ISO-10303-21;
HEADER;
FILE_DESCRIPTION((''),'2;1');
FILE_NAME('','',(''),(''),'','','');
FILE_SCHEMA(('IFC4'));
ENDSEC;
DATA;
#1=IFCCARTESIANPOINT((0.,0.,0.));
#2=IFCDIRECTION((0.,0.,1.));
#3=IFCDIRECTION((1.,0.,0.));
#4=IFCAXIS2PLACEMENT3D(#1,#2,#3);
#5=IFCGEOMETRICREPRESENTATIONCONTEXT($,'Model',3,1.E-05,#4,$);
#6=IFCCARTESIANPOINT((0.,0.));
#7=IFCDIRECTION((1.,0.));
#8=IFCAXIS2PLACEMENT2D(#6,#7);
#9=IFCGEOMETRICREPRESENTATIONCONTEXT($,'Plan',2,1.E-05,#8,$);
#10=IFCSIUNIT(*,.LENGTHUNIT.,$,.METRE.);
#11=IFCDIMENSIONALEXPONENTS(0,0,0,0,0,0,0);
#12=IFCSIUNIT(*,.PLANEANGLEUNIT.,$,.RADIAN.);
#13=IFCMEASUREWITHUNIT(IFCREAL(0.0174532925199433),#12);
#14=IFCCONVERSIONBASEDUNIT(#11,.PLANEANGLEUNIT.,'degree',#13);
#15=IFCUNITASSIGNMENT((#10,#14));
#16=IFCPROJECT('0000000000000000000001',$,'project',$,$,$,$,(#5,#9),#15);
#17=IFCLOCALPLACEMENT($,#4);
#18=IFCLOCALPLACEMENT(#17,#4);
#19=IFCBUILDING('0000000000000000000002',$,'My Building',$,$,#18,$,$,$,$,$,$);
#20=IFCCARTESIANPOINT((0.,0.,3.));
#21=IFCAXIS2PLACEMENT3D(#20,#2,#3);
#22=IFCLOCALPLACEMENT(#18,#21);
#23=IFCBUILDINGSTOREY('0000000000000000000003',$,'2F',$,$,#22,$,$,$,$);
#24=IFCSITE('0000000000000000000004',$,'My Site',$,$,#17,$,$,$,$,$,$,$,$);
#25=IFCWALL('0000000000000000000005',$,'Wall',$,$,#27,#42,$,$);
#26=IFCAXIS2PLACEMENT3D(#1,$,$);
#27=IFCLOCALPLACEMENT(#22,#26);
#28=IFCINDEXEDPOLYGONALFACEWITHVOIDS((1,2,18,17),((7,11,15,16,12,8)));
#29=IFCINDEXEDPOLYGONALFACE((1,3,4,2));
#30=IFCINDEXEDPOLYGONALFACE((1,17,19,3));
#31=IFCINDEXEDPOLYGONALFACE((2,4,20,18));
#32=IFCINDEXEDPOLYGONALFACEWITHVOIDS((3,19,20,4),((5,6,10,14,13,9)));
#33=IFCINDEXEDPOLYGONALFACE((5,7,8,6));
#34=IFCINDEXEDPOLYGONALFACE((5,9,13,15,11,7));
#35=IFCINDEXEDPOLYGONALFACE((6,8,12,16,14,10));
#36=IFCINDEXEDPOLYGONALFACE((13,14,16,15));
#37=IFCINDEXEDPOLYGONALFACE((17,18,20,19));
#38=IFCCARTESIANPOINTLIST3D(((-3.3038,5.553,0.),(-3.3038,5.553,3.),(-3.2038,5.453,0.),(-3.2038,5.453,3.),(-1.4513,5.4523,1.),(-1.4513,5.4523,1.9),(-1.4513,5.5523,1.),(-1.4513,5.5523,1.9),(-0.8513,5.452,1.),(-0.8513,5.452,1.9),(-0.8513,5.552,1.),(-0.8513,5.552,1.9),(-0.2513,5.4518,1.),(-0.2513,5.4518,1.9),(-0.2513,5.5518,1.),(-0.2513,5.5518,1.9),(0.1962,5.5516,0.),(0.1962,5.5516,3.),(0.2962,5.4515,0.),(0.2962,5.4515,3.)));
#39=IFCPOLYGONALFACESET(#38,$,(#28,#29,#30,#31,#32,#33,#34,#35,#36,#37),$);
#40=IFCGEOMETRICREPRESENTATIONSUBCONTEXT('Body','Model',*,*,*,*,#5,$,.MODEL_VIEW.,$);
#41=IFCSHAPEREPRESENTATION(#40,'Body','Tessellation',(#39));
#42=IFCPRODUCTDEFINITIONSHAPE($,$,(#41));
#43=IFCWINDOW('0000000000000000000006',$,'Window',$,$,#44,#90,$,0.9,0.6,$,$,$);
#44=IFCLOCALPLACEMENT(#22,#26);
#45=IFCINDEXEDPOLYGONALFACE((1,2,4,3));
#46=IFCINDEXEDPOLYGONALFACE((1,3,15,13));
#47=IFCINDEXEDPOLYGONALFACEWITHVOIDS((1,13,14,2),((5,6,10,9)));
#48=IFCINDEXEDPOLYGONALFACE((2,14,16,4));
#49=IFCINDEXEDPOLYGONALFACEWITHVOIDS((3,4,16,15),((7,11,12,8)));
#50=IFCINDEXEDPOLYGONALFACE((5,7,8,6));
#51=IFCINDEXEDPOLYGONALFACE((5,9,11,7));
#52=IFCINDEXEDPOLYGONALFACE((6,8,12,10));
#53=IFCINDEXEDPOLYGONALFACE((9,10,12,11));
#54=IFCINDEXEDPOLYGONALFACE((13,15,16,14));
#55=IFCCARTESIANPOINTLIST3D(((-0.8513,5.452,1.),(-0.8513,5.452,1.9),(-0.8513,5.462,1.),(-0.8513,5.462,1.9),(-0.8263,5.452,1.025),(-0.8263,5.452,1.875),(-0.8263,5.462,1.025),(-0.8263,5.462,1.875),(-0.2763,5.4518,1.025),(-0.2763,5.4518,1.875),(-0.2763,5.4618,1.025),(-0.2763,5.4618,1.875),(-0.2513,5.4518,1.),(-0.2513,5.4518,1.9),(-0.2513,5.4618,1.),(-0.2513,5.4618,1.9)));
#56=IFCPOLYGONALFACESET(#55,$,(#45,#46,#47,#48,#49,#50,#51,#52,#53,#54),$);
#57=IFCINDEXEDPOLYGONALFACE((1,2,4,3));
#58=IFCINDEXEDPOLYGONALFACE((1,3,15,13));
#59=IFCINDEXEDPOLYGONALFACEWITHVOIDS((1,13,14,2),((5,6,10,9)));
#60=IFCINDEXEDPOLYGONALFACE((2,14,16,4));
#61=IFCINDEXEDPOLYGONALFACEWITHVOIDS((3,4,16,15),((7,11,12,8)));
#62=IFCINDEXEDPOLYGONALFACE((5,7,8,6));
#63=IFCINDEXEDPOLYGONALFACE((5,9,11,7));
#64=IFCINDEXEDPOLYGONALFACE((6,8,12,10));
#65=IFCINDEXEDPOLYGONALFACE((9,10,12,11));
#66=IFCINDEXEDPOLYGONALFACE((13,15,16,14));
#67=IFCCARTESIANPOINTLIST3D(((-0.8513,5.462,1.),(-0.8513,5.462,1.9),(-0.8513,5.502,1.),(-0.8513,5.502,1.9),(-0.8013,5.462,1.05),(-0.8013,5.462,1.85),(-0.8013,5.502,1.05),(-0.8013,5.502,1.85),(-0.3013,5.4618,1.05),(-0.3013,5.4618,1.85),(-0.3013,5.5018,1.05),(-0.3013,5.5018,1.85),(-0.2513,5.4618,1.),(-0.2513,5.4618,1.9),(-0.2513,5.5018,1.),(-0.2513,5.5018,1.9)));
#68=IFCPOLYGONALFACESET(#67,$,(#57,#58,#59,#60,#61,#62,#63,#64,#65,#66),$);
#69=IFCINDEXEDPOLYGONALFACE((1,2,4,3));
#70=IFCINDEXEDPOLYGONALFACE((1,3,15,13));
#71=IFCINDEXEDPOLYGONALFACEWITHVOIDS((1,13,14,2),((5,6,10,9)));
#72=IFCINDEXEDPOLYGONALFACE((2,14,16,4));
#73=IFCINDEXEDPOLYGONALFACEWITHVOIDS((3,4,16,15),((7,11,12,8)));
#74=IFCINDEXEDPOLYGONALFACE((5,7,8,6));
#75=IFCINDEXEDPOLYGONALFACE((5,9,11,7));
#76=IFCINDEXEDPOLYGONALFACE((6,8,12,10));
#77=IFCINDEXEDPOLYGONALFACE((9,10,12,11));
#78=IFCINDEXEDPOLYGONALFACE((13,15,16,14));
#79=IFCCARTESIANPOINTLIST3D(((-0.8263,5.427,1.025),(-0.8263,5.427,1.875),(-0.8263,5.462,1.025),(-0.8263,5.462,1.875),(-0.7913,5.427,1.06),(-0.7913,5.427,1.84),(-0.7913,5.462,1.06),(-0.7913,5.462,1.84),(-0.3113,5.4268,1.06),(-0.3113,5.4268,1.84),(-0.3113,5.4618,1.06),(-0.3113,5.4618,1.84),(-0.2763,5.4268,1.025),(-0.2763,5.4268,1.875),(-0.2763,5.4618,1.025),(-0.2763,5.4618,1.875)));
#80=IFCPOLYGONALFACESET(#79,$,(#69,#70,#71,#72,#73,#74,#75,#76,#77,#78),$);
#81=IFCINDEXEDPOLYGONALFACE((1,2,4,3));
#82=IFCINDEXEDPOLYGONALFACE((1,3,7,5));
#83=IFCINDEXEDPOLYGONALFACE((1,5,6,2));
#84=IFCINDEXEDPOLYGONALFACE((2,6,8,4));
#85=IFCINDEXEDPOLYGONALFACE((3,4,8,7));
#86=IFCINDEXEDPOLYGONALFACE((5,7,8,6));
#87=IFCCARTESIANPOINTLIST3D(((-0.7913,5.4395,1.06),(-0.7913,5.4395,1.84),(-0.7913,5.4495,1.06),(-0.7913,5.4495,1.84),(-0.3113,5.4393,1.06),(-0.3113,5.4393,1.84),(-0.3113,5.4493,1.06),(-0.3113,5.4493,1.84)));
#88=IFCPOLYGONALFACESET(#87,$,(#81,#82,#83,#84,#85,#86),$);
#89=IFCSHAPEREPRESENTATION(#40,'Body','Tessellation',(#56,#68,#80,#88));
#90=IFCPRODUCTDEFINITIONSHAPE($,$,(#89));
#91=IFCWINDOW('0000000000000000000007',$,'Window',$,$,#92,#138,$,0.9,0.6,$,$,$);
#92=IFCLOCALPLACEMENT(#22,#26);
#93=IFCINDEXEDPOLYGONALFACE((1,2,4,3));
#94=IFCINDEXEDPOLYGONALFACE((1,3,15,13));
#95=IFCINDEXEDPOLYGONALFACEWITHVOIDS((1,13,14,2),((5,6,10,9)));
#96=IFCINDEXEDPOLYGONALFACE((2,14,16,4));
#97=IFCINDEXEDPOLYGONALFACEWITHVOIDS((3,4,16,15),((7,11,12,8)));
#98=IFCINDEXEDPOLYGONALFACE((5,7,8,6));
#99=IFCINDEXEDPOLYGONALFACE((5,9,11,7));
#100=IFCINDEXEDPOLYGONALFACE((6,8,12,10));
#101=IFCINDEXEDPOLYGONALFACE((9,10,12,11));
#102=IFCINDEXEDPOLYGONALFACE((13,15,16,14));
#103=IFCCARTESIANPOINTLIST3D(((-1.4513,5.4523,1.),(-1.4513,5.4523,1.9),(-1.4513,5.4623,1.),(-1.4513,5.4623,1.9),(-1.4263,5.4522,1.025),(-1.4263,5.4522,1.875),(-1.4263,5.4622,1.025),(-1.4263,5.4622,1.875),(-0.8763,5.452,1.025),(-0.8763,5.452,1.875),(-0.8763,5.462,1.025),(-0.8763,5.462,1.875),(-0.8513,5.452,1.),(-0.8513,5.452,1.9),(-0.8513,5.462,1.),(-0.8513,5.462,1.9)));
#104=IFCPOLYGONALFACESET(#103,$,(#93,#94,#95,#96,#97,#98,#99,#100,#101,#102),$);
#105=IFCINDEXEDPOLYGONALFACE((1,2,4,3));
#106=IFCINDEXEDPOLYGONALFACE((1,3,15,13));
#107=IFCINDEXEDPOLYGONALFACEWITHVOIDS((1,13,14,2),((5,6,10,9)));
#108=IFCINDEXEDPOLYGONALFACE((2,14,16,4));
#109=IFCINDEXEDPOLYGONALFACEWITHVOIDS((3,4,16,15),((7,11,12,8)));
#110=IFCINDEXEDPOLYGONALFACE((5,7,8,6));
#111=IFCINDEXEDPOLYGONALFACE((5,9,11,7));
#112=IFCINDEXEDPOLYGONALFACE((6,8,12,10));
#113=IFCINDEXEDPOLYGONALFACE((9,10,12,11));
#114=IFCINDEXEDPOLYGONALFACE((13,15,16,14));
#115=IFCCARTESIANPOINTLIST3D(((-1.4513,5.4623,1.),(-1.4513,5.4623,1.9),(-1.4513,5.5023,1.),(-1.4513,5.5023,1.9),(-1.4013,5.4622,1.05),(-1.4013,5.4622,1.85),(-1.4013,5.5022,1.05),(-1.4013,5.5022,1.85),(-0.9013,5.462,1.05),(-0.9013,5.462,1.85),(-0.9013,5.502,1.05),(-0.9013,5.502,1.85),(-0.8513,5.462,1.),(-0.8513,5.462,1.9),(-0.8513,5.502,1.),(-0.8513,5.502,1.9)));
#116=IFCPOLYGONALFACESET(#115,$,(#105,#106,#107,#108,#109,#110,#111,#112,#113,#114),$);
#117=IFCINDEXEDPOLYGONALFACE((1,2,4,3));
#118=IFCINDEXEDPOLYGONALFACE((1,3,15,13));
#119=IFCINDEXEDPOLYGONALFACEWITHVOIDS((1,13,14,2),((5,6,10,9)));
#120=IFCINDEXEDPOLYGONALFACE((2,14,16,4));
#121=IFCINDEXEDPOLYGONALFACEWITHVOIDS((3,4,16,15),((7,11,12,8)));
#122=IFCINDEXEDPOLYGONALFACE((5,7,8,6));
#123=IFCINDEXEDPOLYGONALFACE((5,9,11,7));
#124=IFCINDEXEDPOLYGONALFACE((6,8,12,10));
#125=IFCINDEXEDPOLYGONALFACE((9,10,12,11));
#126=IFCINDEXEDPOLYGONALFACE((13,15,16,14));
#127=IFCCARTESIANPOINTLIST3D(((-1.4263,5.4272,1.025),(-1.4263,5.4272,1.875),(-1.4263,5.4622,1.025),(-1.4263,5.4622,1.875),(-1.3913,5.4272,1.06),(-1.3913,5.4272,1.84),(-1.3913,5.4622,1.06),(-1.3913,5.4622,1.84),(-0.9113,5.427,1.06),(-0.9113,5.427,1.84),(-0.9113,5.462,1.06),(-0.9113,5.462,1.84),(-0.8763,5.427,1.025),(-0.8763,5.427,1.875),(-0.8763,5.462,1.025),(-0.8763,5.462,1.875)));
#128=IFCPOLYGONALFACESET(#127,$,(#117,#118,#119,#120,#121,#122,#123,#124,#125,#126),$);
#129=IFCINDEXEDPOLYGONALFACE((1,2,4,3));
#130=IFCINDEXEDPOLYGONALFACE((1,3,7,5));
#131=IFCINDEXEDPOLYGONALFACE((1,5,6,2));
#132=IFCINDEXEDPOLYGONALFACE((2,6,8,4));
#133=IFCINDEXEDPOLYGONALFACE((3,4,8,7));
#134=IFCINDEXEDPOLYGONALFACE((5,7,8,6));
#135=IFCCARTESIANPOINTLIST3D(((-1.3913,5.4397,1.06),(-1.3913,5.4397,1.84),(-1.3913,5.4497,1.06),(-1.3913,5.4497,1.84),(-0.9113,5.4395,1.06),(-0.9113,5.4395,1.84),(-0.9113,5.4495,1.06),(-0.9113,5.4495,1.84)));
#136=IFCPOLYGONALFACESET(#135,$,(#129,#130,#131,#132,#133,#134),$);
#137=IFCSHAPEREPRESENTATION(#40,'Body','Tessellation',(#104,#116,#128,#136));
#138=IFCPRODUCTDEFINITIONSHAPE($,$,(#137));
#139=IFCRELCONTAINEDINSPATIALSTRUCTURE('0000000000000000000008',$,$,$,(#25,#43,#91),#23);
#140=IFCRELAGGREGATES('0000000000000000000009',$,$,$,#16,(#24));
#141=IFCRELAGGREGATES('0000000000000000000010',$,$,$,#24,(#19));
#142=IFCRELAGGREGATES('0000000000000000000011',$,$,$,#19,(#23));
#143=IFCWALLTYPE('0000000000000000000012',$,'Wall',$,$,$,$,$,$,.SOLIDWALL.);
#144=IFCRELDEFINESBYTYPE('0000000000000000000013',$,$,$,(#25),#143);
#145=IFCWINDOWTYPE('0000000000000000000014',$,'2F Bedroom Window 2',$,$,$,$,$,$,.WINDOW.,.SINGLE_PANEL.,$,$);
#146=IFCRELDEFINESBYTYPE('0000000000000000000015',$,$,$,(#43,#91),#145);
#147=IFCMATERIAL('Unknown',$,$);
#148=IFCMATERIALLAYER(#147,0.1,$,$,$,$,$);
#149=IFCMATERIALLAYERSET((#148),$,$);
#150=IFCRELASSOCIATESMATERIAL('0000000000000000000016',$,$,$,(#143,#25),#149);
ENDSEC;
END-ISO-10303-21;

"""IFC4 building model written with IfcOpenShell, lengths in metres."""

from ifc_helpers import new_model, entity, si_unit, converted_unit, frame, origin_with_axes, origin_2d_with_axis, place, context, subcontext, project, spatial, line, indexed_curve, outline, extrude, shape, source, transform, mapped, material, layer, layer_set, layer_usage, type_object, type_shapes, element, fill, save


model = new_model("IFC4")

# Units and contexts
model_context = context("Model", 3, precision=1e-05, world=origin_with_axes())
plan_context = context("Plan", 2, precision=1e-05, world=origin_2d_with_axis())
body_context_1 = subcontext(model_context, "Body", "Model", "MODEL_VIEW")
body_context_2 = subcontext(plan_context, "Body", "Plan", "PLAN_VIEW")
ifc_project = project(units=[si_unit("LENGTHUNIT", "METRE"), converted_unit("PLANEANGLEUNIT", "degree", entity("IfcReal", 0.0174532925199433), si_unit("PLANEANGLEUNIT", "RADIAN"), dimensions=[0, 0, 0, 0, 0, 0, 0])], contexts=[model_context, plan_context])

# Site, building, storey
site_placement = place(None, origin_with_axes())
site = spatial("IfcSite", under=ifc_project, at=site_placement, Name="My Site")
building_placement = place(site_placement, origin_with_axes())
building = spatial("IfcBuilding", under=site, at=building_placement, Name="My Building")
storey_placement = place(building_placement, frame((0.0, 0.0, 3.0), z_axis=(0.0, 0.0, 1.0), x_axis=(1.0, 0.0, 0.0)))
storey = spatial("IfcBuildingStorey", under=building, at=storey_placement, Name="2F")

# Shared definitions
ifc_material = material(Name="Unknown")

# Shared definitions
ifc_layer_1 = layer(ifc_material, 0.1)
ifc_layer_set_1 = layer_set([ifc_layer_1])
wall_type = type_object("IfcWallType", Name="Wall", PredefinedType="SOLIDWALL", material=ifc_layer_set_1)

# Wall, openings, windows
ifc_layer_usage_1 = layer_usage(ifc_layer_set_1, "AXIS2", "POSITIVE", 0.0)
wall_1_placement = place(storey_placement, frame((0.1962, 5.5516, 0.0), z_axis=(0.0, 0.0, 1.0), x_axis=(-1.0, 0.000416, 0.0)))
wall_1 = element("IfcWall", 1, at=wall_1_placement, inside=storey, type_object=wall_type, material=ifc_layer_usage_1, Name="Wall", context=body_context_1, shape_type="SweptSolid", body=[
    extrude(outline(indexed_curve([(0.0, 0.0), (-0.1, 0.1), (3.4, 0.1), (3.5, 0.0)], segments=[line(1, 2, 3, 4, 1)])), origin_with_axes(), (0.0, 0.0, 1.0), 3.0),
])
shared_shape_1 = source(origin_with_axes(), body_context_1, "Body", "SweptSolid", [
    extrude(outline(indexed_curve([(0.0, 0.0), (0.6, 0.0), (0.6, 0.9), (0.0, 0.9)], segments=[line(1, 2, 3, 4, 1)])), frame((0.0, -0.6, 0.0), z_axis=(0.0, -1.0, 0.0), x_axis=(1.0, 0.0, 0.0)), (0.0, 0.0, -1.0), 1.2),
])
opening_1_placement = place(wall_1_placement, frame((0.4475, 0.0, 1.0), z_axis=(0.0, 0.0, 1.0), x_axis=(1.0, 0.0, 0.0)))
opening_1 = element("IfcOpeningElement", 2, at=opening_1_placement, cuts=wall_1, PredefinedType="OPENING", context=body_context_1, shape_type="MappedRepresentation", body=[
    mapped(shared_shape_1, transform((0.0, 0.0, 0.0), x_axis=(1.0, 0.0, 0.0), y_axis=(0.0, 1.0, 0.0), z_axis=(0.0, 0.0, 1.0), scale=1.0)),
])
opening_2_placement = place(wall_1_placement, frame((1.0475, 0.0, 1.0), z_axis=(0.0, 0.0, 1.0), x_axis=(1.0, 0.0, 0.0)))
opening_2 = element("IfcOpeningElement", 3, at=opening_2_placement, cuts=wall_1, PredefinedType="OPENING", context=body_context_1, shape_type="MappedRepresentation", body=[
    mapped(shared_shape_1, transform((0.0, 0.0, 0.0), x_axis=(1.0, 0.0, 0.0), y_axis=(0.0, 1.0, 0.0), z_axis=(0.0, 0.0, 1.0), scale=1.0)),
])
window_type_1 = type_object("IfcWindowType", Name="2F Bedroom Window 2", PartitioningType="SINGLE_PANEL", PredefinedType="WINDOW")
shared_shape_2 = source(origin_with_axes(), body_context_1, "Body", "SweptSolid", [
    extrude(outline(indexed_curve([(0.0, 0.0), (0.6, 0.0), (0.6, 0.9), (0.0, 0.9)], segments=[line(1, 2, 3, 4, 1)]), holes=[indexed_curve([(0.025, 0.025), (0.575, 0.025), (0.575, 0.875), (0.025, 0.875)], segments=[line(1, 2, 3, 4, 1)])]), frame((0.0, 0.09, 0.0), z_axis=(0.0, -1.0, 0.0), x_axis=(1.0, 0.0, 0.0)), (0.0, 0.0, -1.0), 0.01),
    extrude(outline(indexed_curve([(0.0, 0.0), (0.6, 0.0), (0.6, 0.9), (0.0, 0.9)], segments=[line(1, 2, 3, 4, 1)]), holes=[indexed_curve([(0.05, 0.05), (0.55, 0.05), (0.55, 0.85), (0.05, 0.85)], segments=[line(1, 2, 3, 4, 1)])]), frame((0.0, 0.05, 0.0), z_axis=(0.0, -1.0, 0.0), x_axis=(1.0, 0.0, 0.0)), (0.0, 0.0, -1.0), 0.04),
    extrude(outline(indexed_curve([(0.0, 0.0), (0.55, 0.0), (0.55, 0.85), (0.0, 0.85)], segments=[line(1, 2, 3, 4, 1)]), holes=[indexed_curve([(0.035, 0.035), (0.515, 0.035), (0.515, 0.815), (0.035, 0.815)], segments=[line(1, 2, 3, 4, 1)])]), frame((0.025, 0.09, 0.025), z_axis=(0.0, -1.0, 0.0), x_axis=(1.0, 0.0, 0.0)), (0.0, 0.0, -1.0), 0.035),
    extrude(outline(indexed_curve([(0.035, 0.035), (0.515, 0.035), (0.515, 0.815), (0.035, 0.815)], segments=[line(1, 2, 3, 4, 1)])), frame((0.025, 0.1025, 0.025), z_axis=(0.0, -1.0, 0.0), x_axis=(1.0, 0.0, 0.0)), (0.0, 0.0, -1.0), 0.01),
])
shared_shape_3 = source(origin_with_axes(), body_context_2, "Body", "Curve2D", [
    entity("IfcIndexedPolyCurve", entity("IfcCartesianPointList2D", [[0.05, 0.05], [0.55, 0.05]])),
    entity("IfcIndexedPolyCurve", entity("IfcCartesianPointList2D", [[0.0, 0.1], [0.025, 0.1], [0.025, 0.09], [0.05, 0.09], [0.05, 0.05], [0.0, 0.05]]), [entity("IfcLineIndex", [1, 2, 3, 4, 5, 6, 1])]),
    entity("IfcIndexedPolyCurve", entity("IfcCartesianPointList2D", [[0.6, 0.1], [0.575, 0.1], [0.575, 0.09], [0.55, 0.09], [0.55, 0.05], [0.6, 0.05]]), [entity("IfcLineIndex", [1, 2, 3, 4, 5, 6, 1])]),
    entity("IfcIndexedPolyCurve", entity("IfcCartesianPointList2D", [[0.025, 0.09], [0.06, 0.09], [0.06, 0.125], [0.025, 0.125]]), [entity("IfcLineIndex", [1, 2, 3, 4, 1])]),
    entity("IfcIndexedPolyCurve", entity("IfcCartesianPointList2D", [[0.575, 0.09], [0.54, 0.09], [0.54, 0.125], [0.575, 0.125]]), [entity("IfcLineIndex", [1, 2, 3, 4, 1])]),
    entity("IfcIndexedPolyCurve", entity("IfcCartesianPointList2D", [[0.06, 0.09], [0.54, 0.09]])),
    entity("IfcIndexedPolyCurve", entity("IfcCartesianPointList2D", [[0.06, 0.125], [0.54, 0.125]])),
    entity("IfcIndexedPolyCurve", entity("IfcCartesianPointList2D", [[0.06, 0.1075], [0.54, 0.1075]])),
])
type_shapes(window_type_1, [shared_shape_2, shared_shape_3])
window_1_placement = place(opening_1_placement, frame((0.0, 0.0, 0.0), z_axis=(0.0, 0.0, 1.0), x_axis=(1.0, 0.0, 0.0)))
window_1 = element("IfcWindow", 4, at=window_1_placement, inside=storey, type_object=window_type_1, Name="Window", OverallHeight=0.9, OverallWidth=0.6, shapes=[
    shape(body_context_1, "Body", "MappedRepresentation", [mapped(shared_shape_2, transform((0.0, 0.0, 0.0), x_axis=(1.0, 0.0, 0.0), y_axis=(0.0, 1.0, 0.0), z_axis=(0.0, 0.0, 1.0), scale=1.0))]),
    shape(body_context_2, "Body", "MappedRepresentation", [mapped(shared_shape_3, transform((0.0, 0.0, 0.0), x_axis=(1.0, 0.0, 0.0), y_axis=(0.0, 1.0, 0.0), z_axis=(0.0, 0.0, 1.0), scale=1.0))]),
])
fill(opening_1, window_1)
window_2_placement = place(opening_2_placement, origin_with_axes())
window_2 = element("IfcWindow", 5, at=window_2_placement, inside=storey, type_object=window_type_1, Name="Window", OverallHeight=0.9, OverallWidth=0.6, shapes=[
    shape(body_context_1, "Body", "MappedRepresentation", [mapped(shared_shape_2, transform((0.0, 0.0, 0.0), x_axis=(1.0, 0.0, 0.0), y_axis=(0.0, 1.0, 0.0), z_axis=(0.0, 0.0, 1.0), scale=1.0))]),
    shape(body_context_2, "Body", "MappedRepresentation", [mapped(shared_shape_3, transform((0.0, 0.0, 0.0), x_axis=(1.0, 0.0, 0.0), y_axis=(0.0, 1.0, 0.0), z_axis=(0.0, 0.0, 1.0), scale=1.0))]),
])
fill(opening_2, window_2)

save(model, "model.ifc")
